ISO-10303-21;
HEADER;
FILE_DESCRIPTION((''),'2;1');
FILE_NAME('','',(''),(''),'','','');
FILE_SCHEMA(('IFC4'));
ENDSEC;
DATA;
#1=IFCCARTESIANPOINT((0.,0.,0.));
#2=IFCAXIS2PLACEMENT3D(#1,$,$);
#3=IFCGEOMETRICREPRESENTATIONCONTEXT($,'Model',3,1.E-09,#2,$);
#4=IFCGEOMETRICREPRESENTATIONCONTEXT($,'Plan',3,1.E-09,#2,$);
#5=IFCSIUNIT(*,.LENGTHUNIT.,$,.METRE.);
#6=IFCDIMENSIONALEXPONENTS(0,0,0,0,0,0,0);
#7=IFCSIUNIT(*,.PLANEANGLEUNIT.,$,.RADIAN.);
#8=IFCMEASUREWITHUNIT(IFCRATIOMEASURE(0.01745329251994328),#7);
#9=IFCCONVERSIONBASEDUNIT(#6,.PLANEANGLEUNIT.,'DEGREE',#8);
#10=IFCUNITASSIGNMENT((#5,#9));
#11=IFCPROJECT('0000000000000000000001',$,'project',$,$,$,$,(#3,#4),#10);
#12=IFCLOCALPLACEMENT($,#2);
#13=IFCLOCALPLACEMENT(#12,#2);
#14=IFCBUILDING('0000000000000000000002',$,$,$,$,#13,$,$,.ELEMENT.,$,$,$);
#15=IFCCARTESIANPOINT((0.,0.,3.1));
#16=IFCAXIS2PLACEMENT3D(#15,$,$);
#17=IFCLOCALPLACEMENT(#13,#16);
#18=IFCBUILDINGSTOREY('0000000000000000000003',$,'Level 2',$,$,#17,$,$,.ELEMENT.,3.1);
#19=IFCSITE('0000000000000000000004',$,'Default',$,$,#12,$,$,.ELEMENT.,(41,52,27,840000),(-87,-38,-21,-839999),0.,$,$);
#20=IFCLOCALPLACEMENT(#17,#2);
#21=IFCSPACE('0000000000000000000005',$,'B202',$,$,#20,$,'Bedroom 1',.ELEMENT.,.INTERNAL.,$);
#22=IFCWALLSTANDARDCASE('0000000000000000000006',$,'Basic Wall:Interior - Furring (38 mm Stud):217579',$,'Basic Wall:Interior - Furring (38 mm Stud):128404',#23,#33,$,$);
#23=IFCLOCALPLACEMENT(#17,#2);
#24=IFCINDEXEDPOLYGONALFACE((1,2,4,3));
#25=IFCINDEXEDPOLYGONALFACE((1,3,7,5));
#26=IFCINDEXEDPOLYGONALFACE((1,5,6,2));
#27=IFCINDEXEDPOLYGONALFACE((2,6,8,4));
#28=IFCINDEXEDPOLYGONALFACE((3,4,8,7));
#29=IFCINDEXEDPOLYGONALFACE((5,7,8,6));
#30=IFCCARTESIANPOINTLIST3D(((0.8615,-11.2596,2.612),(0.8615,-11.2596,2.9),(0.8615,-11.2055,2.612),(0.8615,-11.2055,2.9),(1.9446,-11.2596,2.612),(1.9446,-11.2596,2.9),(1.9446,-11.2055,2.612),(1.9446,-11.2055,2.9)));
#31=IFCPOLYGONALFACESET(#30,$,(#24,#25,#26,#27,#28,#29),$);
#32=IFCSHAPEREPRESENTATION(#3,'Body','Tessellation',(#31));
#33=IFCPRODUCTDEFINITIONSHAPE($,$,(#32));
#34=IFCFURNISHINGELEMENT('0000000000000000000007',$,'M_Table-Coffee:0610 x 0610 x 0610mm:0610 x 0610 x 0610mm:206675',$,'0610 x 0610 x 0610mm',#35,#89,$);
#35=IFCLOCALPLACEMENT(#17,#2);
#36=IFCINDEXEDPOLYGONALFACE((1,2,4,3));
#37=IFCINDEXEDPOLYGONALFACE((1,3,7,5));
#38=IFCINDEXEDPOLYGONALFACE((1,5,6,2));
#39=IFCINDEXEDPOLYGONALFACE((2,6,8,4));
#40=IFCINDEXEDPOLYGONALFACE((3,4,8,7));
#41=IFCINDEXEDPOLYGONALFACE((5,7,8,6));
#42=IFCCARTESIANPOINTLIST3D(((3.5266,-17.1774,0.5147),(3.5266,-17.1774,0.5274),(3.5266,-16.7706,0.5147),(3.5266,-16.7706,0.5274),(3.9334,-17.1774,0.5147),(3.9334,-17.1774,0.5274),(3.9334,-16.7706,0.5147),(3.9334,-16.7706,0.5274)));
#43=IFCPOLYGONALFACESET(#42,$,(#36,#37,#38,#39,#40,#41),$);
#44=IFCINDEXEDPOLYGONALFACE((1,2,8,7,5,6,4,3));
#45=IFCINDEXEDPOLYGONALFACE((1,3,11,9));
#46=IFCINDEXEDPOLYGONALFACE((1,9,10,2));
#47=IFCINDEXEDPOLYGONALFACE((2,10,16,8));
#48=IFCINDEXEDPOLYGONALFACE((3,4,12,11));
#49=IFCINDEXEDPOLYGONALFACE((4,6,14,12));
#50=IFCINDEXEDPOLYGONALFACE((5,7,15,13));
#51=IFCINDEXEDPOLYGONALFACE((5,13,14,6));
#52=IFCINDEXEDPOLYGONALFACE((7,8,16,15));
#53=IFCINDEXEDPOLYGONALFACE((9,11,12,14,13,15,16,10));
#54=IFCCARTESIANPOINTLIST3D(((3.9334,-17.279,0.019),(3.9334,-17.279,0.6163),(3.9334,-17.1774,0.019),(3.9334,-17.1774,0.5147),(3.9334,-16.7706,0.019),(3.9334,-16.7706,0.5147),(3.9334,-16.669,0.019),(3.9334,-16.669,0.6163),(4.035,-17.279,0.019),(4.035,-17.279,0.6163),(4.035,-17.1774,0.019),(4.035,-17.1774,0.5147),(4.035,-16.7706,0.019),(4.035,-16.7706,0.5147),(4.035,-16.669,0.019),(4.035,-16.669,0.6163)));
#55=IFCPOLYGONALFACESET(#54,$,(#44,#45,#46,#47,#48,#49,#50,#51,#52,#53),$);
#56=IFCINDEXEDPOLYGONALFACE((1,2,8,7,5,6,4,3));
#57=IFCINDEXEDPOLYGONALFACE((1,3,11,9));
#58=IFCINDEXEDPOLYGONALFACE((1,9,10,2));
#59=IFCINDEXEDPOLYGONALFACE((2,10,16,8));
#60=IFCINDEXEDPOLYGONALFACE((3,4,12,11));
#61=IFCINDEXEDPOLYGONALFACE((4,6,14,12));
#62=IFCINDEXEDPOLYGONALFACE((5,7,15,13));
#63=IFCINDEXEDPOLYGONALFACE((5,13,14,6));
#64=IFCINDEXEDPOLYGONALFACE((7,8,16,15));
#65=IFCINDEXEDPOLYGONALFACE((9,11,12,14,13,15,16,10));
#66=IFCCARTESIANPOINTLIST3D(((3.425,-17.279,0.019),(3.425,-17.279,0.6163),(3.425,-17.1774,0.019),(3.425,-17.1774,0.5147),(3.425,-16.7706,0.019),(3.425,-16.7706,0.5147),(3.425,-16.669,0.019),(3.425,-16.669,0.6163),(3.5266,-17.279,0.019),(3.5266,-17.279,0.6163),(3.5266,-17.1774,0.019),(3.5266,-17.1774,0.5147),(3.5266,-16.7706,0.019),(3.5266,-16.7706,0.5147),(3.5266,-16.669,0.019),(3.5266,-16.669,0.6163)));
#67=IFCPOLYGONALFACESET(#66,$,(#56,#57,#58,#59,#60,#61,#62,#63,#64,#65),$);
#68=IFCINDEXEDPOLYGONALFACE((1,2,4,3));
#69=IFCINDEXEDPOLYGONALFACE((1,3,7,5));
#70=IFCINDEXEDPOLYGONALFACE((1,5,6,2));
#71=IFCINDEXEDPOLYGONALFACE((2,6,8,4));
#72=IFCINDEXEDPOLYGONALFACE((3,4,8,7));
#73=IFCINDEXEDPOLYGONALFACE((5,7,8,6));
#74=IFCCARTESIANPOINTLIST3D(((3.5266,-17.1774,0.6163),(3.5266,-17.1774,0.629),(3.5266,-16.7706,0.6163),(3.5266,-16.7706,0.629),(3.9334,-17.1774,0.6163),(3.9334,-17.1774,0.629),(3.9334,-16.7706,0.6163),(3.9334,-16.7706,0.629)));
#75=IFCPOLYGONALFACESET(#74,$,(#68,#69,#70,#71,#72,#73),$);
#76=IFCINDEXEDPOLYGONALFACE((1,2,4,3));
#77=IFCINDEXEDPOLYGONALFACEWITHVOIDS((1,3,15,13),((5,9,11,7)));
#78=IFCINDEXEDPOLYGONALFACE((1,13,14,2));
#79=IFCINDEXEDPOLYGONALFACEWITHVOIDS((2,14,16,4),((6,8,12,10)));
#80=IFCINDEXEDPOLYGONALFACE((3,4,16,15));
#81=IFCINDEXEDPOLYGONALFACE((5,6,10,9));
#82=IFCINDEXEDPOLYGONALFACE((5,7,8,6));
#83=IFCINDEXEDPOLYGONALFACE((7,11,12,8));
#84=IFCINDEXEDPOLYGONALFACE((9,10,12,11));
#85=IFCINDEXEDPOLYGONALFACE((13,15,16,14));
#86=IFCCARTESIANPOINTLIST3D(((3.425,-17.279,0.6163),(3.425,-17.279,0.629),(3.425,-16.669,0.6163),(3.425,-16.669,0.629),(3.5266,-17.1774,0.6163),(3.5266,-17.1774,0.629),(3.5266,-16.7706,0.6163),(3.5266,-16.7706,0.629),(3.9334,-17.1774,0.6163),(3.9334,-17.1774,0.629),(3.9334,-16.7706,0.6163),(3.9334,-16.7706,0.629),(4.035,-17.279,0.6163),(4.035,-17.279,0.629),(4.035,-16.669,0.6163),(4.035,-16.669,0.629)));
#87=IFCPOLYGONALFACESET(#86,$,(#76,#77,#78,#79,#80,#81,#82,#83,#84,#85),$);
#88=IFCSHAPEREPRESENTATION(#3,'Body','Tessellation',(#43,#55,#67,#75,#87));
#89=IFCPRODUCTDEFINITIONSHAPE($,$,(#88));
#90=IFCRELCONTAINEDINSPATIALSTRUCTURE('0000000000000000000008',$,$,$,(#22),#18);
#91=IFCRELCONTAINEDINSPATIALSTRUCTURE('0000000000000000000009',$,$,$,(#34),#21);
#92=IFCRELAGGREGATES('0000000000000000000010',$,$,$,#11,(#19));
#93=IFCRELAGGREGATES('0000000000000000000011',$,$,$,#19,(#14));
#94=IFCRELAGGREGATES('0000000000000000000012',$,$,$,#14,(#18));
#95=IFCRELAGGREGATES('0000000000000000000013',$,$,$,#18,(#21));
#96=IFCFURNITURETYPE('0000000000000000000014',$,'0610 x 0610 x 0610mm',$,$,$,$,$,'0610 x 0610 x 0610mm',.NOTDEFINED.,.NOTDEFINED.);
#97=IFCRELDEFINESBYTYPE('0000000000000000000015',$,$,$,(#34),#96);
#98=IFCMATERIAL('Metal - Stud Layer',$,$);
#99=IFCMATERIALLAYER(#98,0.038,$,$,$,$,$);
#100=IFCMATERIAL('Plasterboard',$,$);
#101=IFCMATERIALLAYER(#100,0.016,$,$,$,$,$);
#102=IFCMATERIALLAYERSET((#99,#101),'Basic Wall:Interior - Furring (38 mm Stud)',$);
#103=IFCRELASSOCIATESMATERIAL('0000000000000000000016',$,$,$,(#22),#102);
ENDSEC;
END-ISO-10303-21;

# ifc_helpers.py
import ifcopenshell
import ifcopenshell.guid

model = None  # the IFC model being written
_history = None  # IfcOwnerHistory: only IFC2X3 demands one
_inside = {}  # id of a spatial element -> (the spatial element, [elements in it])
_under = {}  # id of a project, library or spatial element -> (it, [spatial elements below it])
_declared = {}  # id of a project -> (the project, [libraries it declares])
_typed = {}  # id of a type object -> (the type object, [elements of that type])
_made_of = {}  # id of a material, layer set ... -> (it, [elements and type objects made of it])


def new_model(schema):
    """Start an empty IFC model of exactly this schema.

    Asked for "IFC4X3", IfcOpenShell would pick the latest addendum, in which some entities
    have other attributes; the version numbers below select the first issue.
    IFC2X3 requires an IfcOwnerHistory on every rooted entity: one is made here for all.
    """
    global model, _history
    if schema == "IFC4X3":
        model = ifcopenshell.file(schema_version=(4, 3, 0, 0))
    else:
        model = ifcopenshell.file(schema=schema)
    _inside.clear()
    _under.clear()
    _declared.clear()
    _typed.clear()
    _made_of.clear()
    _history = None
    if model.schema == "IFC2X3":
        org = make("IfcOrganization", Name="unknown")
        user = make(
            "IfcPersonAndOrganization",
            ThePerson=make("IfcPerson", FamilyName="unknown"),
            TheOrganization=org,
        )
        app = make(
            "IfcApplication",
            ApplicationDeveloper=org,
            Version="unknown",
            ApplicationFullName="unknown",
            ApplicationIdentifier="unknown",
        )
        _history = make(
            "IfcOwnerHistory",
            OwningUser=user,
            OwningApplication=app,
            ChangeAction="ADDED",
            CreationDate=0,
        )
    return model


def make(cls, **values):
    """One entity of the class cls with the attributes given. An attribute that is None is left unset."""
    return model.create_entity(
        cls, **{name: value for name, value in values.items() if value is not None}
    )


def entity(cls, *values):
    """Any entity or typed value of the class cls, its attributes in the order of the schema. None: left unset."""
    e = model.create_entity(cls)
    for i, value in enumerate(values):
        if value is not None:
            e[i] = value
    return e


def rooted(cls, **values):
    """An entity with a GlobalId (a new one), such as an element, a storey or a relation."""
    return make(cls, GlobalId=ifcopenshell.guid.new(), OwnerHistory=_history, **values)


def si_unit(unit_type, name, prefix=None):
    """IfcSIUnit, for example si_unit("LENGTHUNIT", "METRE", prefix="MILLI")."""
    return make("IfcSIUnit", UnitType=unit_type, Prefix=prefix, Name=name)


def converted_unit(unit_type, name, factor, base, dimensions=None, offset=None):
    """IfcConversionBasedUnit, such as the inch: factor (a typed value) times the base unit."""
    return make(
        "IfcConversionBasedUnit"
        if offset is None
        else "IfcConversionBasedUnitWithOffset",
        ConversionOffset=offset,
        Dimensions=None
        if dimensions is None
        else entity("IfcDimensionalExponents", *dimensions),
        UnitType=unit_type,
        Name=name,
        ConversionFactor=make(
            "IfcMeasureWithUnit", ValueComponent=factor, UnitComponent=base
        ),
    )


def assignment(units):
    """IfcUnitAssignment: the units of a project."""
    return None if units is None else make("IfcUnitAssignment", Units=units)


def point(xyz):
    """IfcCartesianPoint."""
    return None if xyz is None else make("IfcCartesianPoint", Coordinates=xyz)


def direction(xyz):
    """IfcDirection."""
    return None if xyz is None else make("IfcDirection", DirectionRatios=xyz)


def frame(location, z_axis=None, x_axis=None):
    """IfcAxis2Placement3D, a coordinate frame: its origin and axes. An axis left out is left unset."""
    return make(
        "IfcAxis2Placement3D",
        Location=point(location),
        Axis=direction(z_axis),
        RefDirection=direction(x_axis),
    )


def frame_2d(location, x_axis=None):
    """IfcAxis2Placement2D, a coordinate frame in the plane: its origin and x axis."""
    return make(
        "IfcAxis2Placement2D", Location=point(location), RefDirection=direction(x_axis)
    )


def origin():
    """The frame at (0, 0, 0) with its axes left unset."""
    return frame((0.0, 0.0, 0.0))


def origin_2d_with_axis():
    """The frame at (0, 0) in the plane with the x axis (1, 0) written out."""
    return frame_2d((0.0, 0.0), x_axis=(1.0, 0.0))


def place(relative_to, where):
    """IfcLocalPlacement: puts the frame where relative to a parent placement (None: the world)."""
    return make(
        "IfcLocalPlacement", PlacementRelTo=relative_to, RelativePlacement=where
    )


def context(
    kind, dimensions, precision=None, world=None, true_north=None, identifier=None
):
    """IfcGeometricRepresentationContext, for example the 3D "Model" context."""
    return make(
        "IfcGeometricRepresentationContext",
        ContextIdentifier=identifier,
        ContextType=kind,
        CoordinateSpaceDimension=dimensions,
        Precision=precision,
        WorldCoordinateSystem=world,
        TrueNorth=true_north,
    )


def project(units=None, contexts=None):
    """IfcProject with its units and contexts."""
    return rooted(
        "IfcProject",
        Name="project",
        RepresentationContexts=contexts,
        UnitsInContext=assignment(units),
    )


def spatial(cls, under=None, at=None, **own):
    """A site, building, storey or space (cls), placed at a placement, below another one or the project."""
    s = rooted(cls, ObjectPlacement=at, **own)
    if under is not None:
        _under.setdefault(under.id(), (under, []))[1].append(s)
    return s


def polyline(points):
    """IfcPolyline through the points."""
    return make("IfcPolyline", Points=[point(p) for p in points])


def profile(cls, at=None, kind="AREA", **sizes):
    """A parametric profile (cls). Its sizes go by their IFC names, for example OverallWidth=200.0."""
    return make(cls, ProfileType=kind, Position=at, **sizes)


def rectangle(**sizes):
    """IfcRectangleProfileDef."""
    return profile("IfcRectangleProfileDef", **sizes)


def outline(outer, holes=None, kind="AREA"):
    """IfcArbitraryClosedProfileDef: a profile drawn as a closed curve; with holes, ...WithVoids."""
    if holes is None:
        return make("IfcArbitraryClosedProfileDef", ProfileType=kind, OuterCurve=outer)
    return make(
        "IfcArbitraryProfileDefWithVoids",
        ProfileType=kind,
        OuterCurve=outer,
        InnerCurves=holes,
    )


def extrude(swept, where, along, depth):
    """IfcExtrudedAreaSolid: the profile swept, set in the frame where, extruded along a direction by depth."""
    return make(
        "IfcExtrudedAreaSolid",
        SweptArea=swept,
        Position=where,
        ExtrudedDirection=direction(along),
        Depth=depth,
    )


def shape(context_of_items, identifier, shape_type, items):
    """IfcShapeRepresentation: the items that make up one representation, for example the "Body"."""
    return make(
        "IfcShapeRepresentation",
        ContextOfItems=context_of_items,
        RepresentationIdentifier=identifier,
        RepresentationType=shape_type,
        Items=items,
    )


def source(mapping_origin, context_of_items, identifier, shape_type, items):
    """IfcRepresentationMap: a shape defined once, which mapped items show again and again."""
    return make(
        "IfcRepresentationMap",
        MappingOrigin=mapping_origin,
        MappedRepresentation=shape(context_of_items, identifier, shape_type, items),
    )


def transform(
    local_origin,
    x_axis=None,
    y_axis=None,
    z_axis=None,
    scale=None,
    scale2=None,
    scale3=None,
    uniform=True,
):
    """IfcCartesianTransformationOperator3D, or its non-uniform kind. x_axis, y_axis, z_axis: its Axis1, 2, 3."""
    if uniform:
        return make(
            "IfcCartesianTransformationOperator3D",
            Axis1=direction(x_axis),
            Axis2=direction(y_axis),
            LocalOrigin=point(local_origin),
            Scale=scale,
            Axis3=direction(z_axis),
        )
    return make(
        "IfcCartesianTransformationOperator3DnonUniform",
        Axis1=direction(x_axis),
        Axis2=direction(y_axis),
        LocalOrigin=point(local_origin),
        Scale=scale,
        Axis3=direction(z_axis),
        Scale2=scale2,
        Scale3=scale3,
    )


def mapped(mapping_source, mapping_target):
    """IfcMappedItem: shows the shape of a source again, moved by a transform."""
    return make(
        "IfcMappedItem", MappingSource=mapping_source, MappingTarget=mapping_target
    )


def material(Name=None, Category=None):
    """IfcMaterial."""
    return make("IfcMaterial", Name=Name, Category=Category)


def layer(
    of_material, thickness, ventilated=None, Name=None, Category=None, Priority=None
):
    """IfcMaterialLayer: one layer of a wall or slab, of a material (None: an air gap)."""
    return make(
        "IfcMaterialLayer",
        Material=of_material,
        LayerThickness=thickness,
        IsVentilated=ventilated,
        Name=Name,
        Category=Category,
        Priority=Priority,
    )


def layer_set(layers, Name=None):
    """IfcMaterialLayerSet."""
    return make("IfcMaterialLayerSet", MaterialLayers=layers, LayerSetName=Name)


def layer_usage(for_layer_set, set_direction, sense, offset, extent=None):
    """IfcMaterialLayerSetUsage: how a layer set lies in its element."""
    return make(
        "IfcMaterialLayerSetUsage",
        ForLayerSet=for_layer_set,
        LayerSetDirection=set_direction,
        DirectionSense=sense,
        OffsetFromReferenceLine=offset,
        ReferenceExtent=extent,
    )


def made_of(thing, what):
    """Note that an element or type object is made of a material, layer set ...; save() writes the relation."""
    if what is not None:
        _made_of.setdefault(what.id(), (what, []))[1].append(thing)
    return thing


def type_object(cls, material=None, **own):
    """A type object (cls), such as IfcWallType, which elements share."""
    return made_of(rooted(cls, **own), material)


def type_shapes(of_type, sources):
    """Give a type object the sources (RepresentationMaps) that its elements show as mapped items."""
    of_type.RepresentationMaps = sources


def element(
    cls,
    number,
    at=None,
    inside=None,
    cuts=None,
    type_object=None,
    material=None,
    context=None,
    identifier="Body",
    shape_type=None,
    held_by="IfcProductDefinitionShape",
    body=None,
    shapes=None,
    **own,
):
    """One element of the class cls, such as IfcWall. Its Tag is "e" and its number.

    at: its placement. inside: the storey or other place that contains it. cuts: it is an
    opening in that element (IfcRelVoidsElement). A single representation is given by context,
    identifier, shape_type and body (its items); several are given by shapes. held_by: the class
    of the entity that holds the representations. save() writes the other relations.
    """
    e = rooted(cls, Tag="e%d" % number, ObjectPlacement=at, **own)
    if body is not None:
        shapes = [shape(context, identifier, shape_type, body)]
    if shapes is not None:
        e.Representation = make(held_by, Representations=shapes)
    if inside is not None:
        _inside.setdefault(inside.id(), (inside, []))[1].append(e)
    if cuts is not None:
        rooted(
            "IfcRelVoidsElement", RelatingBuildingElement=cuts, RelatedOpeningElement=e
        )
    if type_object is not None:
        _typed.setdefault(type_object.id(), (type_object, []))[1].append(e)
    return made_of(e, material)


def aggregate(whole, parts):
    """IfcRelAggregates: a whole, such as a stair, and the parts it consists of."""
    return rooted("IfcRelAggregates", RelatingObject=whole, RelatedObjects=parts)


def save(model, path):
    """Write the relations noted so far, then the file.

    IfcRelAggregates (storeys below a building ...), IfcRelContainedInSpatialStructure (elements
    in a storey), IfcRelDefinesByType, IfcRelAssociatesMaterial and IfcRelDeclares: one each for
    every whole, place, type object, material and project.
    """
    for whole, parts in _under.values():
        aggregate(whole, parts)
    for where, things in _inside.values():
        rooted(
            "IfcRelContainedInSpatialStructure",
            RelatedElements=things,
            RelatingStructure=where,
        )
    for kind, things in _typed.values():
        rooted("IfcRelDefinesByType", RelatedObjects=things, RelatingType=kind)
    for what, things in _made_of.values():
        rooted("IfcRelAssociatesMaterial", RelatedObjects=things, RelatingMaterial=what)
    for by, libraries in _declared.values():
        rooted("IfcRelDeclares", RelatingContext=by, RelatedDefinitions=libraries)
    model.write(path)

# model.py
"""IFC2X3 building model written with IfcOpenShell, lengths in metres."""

from ifc_helpers import new_model, entity, si_unit, converted_unit, frame, frame_2d, origin, origin_2d_with_axis, place, context, project, spatial, polyline, rectangle, outline, extrude, source, transform, mapped, material, layer, layer_set, layer_usage, type_object, type_shapes, element, save


model = new_model("IFC2X3")

# Units and contexts
model_context = context("Model", 3, precision=1e-09, world=origin())
plan_context = context("Plan", 3, precision=1e-09, world=origin())
ifc_project = project(units=[si_unit("LENGTHUNIT", "METRE"), converted_unit("PLANEANGLEUNIT", "DEGREE", entity("IfcRatioMeasure", 0.01745329251994328), si_unit("PLANEANGLEUNIT", "RADIAN"), dimensions=[0, 0, 0, 0, 0, 0, 0])], contexts=[model_context, plan_context])

# Site, building, storey
site_placement = place(None, origin())
site = spatial("IfcSite", under=ifc_project, at=site_placement, Name="Default", CompositionType="ELEMENT", RefLatitude=(41, 52, 27, 840000), RefLongitude=(-87, -38, -21, -839999), RefElevation=0.0)
building_placement = place(site_placement, origin())
building = spatial("IfcBuilding", under=site, at=building_placement, CompositionType="ELEMENT")
storey_placement = place(building_placement, frame((0.0, 0.0, 3.1)))
storey = spatial("IfcBuildingStorey", under=building, at=storey_placement, Name="Level 2", CompositionType="ELEMENT", Elevation=3.1)

# Shared definitions
ifc_material_1 = material(Name="Metal - Stud Layer")
ifc_material_2 = material(Name="Plasterboard")

# Wall
ifc_layer_1 = layer(ifc_material_1, 0.038)
ifc_layer_2 = layer(ifc_material_2, 0.016)
ifc_layer_set_1 = layer_set([ifc_layer_1, ifc_layer_2], Name="Basic Wall:Interior - Furring (38 mm Stud)")
ifc_layer_usage_1 = layer_usage(ifc_layer_set_1, "AXIS2", "NEGATIVE", 0.027)
wall_1_placement = place(storey_placement, frame((1.9446, -11.2325, 2.612), z_axis=(0.0, 0.0, 1.0), x_axis=(-1.0, 0.0, 0.0)))
element("IfcWallStandardCase", 1, at=wall_1_placement, inside=storey, material=ifc_layer_usage_1, Name="Basic Wall:Interior - Furring (38 mm Stud):217579", ObjectType="Basic Wall:Interior - Furring (38 mm Stud):128404", context=model_context, shape_type="SweptSolid", body=[
    extrude(rectangle(XDim=1.0831, YDim=0.054, at=frame_2d((0.5415, 0.0), x_axis=(-1.0, 0.0))), origin(), (0.0, 0.0, 1.0), 0.288),
])

# Shared definitions
space_placement = place(storey_placement, origin())
space = spatial("IfcSpace", under=storey, at=space_placement, Name="B202", LongName="Bedroom 1", CompositionType="ELEMENT", InteriorOrExteriorSpace="INTERNAL")

# Furnishing element
furniture_type = type_object("IfcFurnitureType", Name="0610 x 0610 x 0610mm", ElementType="0610 x 0610 x 0610mm", AssemblyPlace="NOTDEFINED")
shared_shape_1 = source(origin(), model_context, "Body", "SweptSolid", [
    extrude(rectangle(XDim=0.4068, YDim=0.4068, at=origin_2d_with_axis()), frame((0.0183, 0.0952, 0.4957), z_axis=(0.0, 0.0, 1.0), x_axis=(-1.0, 0.0, 0.0)), (0.0, 0.0, 1.0), 0.0127),
    extrude(outline(polyline([(-0.2732, -0.305), (0.324, -0.305), (0.324, 0.305), (-0.2732, 0.305), (-0.2732, 0.2034), (0.2225, 0.2034), (0.2225, -0.2034), (-0.2732, -0.2034), (-0.2732, -0.305)])), frame((0.2217, 0.0952, 0.2732), z_axis=(1.0, 0.0, 0.0), x_axis=(0.0, 0.0, 1.0)), (0.0, 0.0, 1.0), 0.1016),
    extrude(outline(polyline([(-0.305, -0.3241), (0.305, -0.3241), (0.305, 0.2733), (0.2034, 0.2733), (0.2034, -0.2224), (-0.2034, -0.2224), (-0.2034, 0.2733), (-0.305, 0.2733), (-0.305, -0.3241)])), frame((-0.2867, 0.0952, 0.2733), z_axis=(1.0, 0.0, 0.0), x_axis=(0.0, -1.0, 0.0)), (0.0, 0.0, 1.0), 0.1016),
    extrude(rectangle(XDim=0.4068, YDim=0.4068, at=origin_2d_with_axis()), frame((0.0183, 0.0952, 0.5973), z_axis=(0.0, 0.0, 1.0), x_axis=(-1.0, 0.0, 0.0)), (0.0, 0.0, 1.0), 0.0127),
    extrude(outline(polyline([(-0.305, -0.305), (0.305, -0.305), (0.305, 0.305), (-0.305, 0.305), (-0.305, -0.305)]), holes=[polyline([(-0.2034, -0.2034), (-0.2034, 0.2034), (0.2034, 0.2034), (0.2034, -0.2034), (-0.2034, -0.2034)])]), frame((0.0183, 0.0952, 0.5973), z_axis=(0.0, 0.0, 1.0), x_axis=(-1.0, 0.0, 0.0)), (0.0, 0.0, 1.0), 0.0127),
])
type_shapes(furniture_type, [shared_shape_1])
furnishing_placement = place(space_placement, frame((3.7117, -17.0692, 0.019)))
element("IfcFurnishingElement", 2, at=furnishing_placement, inside=space, type_object=furniture_type, Name="M_Table-Coffee:0610 x 0610 x 0610mm:0610 x 0610 x 0610mm:206675", ObjectType="0610 x 0610 x 0610mm", context=model_context, shape_type="MappedRepresentation", body=[
    mapped(shared_shape_1, transform((0.0, 0.0, 0.0), scale=1.0)),
])

save(model, "model.ifc")
